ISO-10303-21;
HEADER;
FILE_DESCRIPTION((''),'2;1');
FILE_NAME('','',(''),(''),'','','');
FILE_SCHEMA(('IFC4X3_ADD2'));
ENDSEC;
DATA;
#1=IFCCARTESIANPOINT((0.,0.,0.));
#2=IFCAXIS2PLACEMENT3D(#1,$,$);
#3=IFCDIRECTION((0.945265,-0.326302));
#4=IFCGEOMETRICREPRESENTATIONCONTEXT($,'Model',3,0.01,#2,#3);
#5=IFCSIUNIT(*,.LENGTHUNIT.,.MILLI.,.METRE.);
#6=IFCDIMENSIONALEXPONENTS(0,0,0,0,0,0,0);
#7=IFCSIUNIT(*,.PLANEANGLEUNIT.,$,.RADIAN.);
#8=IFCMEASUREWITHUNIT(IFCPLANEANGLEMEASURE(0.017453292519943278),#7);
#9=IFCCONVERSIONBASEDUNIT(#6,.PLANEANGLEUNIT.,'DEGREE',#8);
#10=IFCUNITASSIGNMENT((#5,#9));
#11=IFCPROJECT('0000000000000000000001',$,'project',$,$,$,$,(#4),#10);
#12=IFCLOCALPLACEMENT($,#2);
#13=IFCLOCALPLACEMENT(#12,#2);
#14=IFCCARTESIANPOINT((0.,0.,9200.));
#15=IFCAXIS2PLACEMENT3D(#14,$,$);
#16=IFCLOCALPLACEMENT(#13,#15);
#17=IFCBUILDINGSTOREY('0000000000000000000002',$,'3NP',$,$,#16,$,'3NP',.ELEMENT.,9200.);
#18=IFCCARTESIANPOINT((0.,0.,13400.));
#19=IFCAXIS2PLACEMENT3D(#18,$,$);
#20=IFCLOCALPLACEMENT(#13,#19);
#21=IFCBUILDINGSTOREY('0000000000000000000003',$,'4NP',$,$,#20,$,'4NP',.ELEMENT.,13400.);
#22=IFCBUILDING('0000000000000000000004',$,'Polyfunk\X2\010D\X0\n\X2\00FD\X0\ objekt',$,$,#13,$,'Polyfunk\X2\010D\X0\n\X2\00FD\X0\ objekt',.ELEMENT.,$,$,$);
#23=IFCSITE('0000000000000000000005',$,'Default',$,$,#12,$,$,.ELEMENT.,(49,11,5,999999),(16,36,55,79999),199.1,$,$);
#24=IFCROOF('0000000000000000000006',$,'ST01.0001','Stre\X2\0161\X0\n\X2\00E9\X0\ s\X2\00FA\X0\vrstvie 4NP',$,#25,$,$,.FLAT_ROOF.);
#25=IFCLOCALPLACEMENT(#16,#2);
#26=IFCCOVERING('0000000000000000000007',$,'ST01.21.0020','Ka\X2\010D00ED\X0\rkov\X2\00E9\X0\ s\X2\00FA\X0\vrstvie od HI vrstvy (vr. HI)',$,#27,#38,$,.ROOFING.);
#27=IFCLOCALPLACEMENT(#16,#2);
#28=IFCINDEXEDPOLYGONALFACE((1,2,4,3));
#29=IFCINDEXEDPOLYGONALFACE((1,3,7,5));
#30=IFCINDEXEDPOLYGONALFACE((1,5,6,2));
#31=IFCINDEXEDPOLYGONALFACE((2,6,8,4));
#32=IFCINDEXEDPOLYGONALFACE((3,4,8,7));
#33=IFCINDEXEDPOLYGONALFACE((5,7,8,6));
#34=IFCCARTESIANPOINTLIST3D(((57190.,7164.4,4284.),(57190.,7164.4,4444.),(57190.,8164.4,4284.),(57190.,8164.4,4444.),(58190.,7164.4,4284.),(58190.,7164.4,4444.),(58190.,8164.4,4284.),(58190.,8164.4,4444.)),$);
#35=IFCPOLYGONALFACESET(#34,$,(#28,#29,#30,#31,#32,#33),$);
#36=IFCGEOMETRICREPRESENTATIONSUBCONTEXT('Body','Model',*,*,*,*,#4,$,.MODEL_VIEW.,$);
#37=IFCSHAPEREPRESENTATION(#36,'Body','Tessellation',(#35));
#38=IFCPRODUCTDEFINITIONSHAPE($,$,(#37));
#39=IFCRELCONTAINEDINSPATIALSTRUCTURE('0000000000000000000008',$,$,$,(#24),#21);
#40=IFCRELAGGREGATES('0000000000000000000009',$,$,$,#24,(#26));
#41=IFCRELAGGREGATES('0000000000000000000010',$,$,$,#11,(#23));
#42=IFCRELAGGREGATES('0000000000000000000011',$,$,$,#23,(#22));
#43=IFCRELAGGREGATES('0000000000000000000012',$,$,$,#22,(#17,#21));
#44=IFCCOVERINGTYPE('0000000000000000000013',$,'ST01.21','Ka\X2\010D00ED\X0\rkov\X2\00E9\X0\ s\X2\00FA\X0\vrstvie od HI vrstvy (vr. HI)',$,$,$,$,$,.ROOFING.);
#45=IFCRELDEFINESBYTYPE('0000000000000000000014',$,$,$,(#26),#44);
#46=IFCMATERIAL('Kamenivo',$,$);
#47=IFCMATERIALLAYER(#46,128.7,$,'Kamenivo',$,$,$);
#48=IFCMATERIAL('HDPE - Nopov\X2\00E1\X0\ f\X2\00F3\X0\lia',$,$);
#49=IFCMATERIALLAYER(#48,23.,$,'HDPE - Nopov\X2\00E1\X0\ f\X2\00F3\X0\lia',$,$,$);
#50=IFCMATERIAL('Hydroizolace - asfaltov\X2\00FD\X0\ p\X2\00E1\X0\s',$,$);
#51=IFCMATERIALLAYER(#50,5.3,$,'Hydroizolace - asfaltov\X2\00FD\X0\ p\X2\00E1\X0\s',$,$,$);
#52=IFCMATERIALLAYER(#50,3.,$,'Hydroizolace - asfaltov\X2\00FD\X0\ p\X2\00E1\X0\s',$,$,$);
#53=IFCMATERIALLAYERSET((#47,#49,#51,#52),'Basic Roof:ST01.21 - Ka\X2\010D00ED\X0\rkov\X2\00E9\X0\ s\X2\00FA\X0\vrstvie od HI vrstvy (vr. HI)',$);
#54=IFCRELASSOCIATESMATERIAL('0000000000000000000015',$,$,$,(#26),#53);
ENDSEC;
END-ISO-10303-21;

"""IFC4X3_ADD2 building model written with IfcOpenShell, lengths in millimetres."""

from ifc_helpers import new_model, entity, si_unit, converted_unit, direction, frame, frame_2d, origin, place, context, subcontext, project, spatial, rectangle, extrude, material, layer, layer_set, type_object, element, aggregate, save


model = new_model("IFC4X3_ADD2")

# Units and contexts
model_context = context("Model", 3, precision=0.01, world=origin(), true_north=direction((0.945265, -0.326302)))
body_context = subcontext(model_context, "Body", "Model", "MODEL_VIEW")
ifc_project = project(units=[si_unit("LENGTHUNIT", "METRE", prefix="MILLI"), converted_unit("PLANEANGLEUNIT", "DEGREE", entity("IfcPlaneAngleMeasure", 0.017453292519943278), si_unit("PLANEANGLEUNIT", "RADIAN"), dimensions=[0, 0, 0, 0, 0, 0, 0])], contexts=[model_context])

# Site, building, storey
site_placement = place(None, origin())
site = spatial("IfcSite", under=ifc_project, at=site_placement, Name="Default", CompositionType="ELEMENT", RefLatitude=(49, 11, 5, 999999), RefLongitude=(16, 36, 55, 79999), RefElevation=199.1)
building_placement = place(site_placement, origin())
building = spatial("IfcBuilding", under=site, at=building_placement, Name="Polyfunkčný objekt", LongName="Polyfunkčný objekt", CompositionType="ELEMENT")
storey_1_placement = place(building_placement, frame((0.0, 0.0, 9200.0)))
storey_1 = spatial("IfcBuildingStorey", under=building, at=storey_1_placement, Name="3NP", LongName="3NP", CompositionType="ELEMENT", Elevation=9200.0)

# Shared definitions
storey_2_placement = place(building_placement, frame((0.0, 0.0, 13400.0)))
storey_2 = spatial("IfcBuildingStorey", under=building, at=storey_2_placement, Name="4NP", LongName="4NP", CompositionType="ELEMENT", Elevation=13400.0)

# Roof, covering
roof = element("IfcRoof", 1, inside=storey_2, Name="ST01.0001", Description="Strešné súvrstvie 4NP", PredefinedType="FLAT_ROOF")
ifc_material_1 = material(Name="HDPE - Nopová fólia")
ifc_material_2 = material(Name="Hydroizolace - asfaltový pás")
ifc_material_3 = material(Name="Kamenivo")
ifc_layer_1 = layer(ifc_material_3, 128.7, Name="Kamenivo")
ifc_layer_2 = layer(ifc_material_1, 23.0, Name="HDPE - Nopová fólia")
ifc_layer_3 = layer(ifc_material_2, 5.3, Name="Hydroizolace - asfaltový pás")
ifc_layer_4 = layer(ifc_material_2, 3.0, Name="Hydroizolace - asfaltový pás")
ifc_layer_set_1 = layer_set([ifc_layer_1, ifc_layer_2, ifc_layer_3, ifc_layer_4], Name="Basic Roof:ST01.21 - Kačírkové súvrstvie od HI vrstvy (vr. HI)")
covering_type_1 = type_object("IfcCoveringType", Name="ST01.21", Description="Kačírkové súvrstvie od HI vrstvy (vr. HI)", PredefinedType="ROOFING")
placement_1 = place(storey_2_placement, frame((57190.0, 7164.4, 84.0)))
covering_1_placement = place(placement_1, origin())
covering_1 = element("IfcCovering", 2, at=covering_1_placement, type_object=covering_type_1, material=ifc_layer_set_1, Name="ST01.21.0020", Description="Kačírkové súvrstvie od HI vrstvy (vr. HI)", PredefinedType="ROOFING", context=body_context, shape_type="SweptSolid", body=[
    extrude(rectangle(XDim=1000.0, YDim=1000.0, at=frame_2d((0.0, 0.0), x_axis=(1.0, 0.0))), frame((500.0, 500.0, 0.0)), (0.0, 0.0, 1.0), 160.0),
])
aggregate(roof, [covering_1])

save(model, "model.ifc")
